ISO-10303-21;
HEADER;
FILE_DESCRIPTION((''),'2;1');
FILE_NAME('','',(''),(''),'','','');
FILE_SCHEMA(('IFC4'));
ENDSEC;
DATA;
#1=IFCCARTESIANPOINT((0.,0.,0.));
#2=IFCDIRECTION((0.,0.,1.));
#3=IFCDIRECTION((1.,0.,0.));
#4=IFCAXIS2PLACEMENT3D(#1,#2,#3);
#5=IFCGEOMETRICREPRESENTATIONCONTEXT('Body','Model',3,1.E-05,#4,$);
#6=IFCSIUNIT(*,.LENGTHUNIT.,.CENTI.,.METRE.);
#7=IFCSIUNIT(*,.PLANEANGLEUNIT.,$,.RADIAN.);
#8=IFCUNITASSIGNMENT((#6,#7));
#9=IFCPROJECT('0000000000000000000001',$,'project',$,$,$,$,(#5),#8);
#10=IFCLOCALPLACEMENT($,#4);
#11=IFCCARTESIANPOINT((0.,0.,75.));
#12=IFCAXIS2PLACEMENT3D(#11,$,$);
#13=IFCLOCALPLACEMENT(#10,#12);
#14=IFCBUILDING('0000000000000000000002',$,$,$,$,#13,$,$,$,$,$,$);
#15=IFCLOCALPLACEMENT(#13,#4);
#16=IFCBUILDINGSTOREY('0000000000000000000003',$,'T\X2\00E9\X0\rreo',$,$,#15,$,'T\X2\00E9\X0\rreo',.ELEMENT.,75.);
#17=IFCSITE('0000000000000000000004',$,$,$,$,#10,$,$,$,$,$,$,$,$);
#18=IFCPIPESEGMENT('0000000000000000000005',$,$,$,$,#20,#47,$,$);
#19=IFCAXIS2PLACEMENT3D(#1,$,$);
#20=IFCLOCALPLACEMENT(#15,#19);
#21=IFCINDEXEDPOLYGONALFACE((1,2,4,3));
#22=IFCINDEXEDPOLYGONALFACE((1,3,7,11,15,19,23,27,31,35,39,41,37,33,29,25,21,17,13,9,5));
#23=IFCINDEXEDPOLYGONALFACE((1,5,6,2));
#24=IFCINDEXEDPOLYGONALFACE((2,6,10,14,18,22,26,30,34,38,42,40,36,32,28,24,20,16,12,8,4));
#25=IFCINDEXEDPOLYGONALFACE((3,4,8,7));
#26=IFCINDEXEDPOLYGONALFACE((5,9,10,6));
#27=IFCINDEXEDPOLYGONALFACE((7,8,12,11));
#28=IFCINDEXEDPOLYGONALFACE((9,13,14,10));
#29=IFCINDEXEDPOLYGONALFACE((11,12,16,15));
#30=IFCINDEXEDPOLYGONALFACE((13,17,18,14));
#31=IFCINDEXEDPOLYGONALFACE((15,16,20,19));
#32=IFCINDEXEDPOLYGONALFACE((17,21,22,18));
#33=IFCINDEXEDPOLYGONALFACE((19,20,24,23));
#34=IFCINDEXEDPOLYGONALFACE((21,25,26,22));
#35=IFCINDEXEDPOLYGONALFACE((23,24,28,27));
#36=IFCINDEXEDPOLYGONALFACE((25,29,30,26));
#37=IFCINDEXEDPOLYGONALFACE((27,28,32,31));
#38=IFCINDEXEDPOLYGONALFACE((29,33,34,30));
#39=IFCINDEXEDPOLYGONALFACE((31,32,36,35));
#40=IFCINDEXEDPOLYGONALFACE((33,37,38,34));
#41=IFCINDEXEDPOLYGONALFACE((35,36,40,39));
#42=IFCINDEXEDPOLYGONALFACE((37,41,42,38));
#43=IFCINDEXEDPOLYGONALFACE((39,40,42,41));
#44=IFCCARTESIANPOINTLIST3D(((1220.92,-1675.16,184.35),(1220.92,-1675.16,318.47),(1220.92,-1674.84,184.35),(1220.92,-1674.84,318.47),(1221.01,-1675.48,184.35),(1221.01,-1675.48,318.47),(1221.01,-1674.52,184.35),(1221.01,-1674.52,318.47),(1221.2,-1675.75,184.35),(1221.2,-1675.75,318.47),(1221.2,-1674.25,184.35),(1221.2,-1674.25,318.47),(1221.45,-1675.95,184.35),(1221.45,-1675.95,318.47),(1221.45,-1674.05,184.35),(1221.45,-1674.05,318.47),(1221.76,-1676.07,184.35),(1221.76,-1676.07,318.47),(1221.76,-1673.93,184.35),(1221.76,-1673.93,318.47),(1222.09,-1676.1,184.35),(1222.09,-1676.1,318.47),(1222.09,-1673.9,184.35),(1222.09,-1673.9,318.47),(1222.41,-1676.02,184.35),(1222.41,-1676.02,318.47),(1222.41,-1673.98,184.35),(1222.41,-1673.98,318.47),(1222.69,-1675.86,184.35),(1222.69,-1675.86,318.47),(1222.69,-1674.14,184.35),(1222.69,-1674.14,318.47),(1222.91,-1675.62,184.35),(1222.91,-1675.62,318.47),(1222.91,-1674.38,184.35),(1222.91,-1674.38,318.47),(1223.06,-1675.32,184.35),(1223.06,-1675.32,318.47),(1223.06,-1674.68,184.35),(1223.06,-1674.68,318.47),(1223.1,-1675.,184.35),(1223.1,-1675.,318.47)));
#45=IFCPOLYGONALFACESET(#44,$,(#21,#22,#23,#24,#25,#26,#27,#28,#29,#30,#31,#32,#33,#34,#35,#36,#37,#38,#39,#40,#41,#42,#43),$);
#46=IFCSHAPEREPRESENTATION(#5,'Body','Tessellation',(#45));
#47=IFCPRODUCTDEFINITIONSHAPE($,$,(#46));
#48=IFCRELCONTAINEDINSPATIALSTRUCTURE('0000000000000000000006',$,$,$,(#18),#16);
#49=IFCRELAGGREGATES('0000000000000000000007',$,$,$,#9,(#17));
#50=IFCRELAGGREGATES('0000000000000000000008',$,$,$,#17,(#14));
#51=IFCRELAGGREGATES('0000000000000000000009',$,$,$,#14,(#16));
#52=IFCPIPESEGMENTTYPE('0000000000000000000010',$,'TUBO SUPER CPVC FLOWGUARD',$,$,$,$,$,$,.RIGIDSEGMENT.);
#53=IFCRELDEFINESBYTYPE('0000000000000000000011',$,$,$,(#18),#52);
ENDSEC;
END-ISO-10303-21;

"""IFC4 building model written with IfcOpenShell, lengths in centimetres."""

from ifc_helpers import new_model, si_unit, frame, origin_with_axes, origin_2d_with_axis, place, context, project, spatial, circle, extrude, type_object, element, save


model = new_model("IFC4")

# Units and contexts
model_context = context("Model", 3, precision=1e-05, world=origin_with_axes(), identifier="Body")
ifc_project = project(units=[si_unit("LENGTHUNIT", "METRE", prefix="CENTI"), si_unit("PLANEANGLEUNIT", "RADIAN")], contexts=[model_context])

# Site, building, storey
site_placement = place(None, origin_with_axes())
site = spatial("IfcSite", under=ifc_project, at=site_placement)
building_placement = place(site_placement, frame((0.0, 0.0, 75.0)))
building = spatial("IfcBuilding", under=site, at=building_placement)
storey_placement = place(building_placement, origin_with_axes())
storey = spatial("IfcBuildingStorey", under=building, at=storey_placement, Name="Térreo", LongName="Térreo", CompositionType="ELEMENT", Elevation=75.0)

# Pipe segment
pipe_segment_type_1 = type_object("IfcPipeSegmentType", Name="TUBO SUPER CPVC FLOWGUARD", PredefinedType="RIGIDSEGMENT")
pipe_segment_1_placement = place(storey_placement, frame((1222.0, -1675.0, 318.47), z_axis=(0.0, 0.0, 1.0), x_axis=(1.0, 0.0, 0.0)))
element("IfcPipeSegment", 1, at=pipe_segment_1_placement, inside=storey, type_object=pipe_segment_type_1, context=model_context, shape_type="SolidModel", body=[
    extrude(circle(Radius=1.1, at=origin_2d_with_axis()), frame((0.0, 0.0, 0.0), z_axis=(0.0, 0.0, -1.0), x_axis=(1.0, 0.0, 0.0)), (0.0, 0.0, 1.0), 134.12),
])

save(model, "model.ifc")
